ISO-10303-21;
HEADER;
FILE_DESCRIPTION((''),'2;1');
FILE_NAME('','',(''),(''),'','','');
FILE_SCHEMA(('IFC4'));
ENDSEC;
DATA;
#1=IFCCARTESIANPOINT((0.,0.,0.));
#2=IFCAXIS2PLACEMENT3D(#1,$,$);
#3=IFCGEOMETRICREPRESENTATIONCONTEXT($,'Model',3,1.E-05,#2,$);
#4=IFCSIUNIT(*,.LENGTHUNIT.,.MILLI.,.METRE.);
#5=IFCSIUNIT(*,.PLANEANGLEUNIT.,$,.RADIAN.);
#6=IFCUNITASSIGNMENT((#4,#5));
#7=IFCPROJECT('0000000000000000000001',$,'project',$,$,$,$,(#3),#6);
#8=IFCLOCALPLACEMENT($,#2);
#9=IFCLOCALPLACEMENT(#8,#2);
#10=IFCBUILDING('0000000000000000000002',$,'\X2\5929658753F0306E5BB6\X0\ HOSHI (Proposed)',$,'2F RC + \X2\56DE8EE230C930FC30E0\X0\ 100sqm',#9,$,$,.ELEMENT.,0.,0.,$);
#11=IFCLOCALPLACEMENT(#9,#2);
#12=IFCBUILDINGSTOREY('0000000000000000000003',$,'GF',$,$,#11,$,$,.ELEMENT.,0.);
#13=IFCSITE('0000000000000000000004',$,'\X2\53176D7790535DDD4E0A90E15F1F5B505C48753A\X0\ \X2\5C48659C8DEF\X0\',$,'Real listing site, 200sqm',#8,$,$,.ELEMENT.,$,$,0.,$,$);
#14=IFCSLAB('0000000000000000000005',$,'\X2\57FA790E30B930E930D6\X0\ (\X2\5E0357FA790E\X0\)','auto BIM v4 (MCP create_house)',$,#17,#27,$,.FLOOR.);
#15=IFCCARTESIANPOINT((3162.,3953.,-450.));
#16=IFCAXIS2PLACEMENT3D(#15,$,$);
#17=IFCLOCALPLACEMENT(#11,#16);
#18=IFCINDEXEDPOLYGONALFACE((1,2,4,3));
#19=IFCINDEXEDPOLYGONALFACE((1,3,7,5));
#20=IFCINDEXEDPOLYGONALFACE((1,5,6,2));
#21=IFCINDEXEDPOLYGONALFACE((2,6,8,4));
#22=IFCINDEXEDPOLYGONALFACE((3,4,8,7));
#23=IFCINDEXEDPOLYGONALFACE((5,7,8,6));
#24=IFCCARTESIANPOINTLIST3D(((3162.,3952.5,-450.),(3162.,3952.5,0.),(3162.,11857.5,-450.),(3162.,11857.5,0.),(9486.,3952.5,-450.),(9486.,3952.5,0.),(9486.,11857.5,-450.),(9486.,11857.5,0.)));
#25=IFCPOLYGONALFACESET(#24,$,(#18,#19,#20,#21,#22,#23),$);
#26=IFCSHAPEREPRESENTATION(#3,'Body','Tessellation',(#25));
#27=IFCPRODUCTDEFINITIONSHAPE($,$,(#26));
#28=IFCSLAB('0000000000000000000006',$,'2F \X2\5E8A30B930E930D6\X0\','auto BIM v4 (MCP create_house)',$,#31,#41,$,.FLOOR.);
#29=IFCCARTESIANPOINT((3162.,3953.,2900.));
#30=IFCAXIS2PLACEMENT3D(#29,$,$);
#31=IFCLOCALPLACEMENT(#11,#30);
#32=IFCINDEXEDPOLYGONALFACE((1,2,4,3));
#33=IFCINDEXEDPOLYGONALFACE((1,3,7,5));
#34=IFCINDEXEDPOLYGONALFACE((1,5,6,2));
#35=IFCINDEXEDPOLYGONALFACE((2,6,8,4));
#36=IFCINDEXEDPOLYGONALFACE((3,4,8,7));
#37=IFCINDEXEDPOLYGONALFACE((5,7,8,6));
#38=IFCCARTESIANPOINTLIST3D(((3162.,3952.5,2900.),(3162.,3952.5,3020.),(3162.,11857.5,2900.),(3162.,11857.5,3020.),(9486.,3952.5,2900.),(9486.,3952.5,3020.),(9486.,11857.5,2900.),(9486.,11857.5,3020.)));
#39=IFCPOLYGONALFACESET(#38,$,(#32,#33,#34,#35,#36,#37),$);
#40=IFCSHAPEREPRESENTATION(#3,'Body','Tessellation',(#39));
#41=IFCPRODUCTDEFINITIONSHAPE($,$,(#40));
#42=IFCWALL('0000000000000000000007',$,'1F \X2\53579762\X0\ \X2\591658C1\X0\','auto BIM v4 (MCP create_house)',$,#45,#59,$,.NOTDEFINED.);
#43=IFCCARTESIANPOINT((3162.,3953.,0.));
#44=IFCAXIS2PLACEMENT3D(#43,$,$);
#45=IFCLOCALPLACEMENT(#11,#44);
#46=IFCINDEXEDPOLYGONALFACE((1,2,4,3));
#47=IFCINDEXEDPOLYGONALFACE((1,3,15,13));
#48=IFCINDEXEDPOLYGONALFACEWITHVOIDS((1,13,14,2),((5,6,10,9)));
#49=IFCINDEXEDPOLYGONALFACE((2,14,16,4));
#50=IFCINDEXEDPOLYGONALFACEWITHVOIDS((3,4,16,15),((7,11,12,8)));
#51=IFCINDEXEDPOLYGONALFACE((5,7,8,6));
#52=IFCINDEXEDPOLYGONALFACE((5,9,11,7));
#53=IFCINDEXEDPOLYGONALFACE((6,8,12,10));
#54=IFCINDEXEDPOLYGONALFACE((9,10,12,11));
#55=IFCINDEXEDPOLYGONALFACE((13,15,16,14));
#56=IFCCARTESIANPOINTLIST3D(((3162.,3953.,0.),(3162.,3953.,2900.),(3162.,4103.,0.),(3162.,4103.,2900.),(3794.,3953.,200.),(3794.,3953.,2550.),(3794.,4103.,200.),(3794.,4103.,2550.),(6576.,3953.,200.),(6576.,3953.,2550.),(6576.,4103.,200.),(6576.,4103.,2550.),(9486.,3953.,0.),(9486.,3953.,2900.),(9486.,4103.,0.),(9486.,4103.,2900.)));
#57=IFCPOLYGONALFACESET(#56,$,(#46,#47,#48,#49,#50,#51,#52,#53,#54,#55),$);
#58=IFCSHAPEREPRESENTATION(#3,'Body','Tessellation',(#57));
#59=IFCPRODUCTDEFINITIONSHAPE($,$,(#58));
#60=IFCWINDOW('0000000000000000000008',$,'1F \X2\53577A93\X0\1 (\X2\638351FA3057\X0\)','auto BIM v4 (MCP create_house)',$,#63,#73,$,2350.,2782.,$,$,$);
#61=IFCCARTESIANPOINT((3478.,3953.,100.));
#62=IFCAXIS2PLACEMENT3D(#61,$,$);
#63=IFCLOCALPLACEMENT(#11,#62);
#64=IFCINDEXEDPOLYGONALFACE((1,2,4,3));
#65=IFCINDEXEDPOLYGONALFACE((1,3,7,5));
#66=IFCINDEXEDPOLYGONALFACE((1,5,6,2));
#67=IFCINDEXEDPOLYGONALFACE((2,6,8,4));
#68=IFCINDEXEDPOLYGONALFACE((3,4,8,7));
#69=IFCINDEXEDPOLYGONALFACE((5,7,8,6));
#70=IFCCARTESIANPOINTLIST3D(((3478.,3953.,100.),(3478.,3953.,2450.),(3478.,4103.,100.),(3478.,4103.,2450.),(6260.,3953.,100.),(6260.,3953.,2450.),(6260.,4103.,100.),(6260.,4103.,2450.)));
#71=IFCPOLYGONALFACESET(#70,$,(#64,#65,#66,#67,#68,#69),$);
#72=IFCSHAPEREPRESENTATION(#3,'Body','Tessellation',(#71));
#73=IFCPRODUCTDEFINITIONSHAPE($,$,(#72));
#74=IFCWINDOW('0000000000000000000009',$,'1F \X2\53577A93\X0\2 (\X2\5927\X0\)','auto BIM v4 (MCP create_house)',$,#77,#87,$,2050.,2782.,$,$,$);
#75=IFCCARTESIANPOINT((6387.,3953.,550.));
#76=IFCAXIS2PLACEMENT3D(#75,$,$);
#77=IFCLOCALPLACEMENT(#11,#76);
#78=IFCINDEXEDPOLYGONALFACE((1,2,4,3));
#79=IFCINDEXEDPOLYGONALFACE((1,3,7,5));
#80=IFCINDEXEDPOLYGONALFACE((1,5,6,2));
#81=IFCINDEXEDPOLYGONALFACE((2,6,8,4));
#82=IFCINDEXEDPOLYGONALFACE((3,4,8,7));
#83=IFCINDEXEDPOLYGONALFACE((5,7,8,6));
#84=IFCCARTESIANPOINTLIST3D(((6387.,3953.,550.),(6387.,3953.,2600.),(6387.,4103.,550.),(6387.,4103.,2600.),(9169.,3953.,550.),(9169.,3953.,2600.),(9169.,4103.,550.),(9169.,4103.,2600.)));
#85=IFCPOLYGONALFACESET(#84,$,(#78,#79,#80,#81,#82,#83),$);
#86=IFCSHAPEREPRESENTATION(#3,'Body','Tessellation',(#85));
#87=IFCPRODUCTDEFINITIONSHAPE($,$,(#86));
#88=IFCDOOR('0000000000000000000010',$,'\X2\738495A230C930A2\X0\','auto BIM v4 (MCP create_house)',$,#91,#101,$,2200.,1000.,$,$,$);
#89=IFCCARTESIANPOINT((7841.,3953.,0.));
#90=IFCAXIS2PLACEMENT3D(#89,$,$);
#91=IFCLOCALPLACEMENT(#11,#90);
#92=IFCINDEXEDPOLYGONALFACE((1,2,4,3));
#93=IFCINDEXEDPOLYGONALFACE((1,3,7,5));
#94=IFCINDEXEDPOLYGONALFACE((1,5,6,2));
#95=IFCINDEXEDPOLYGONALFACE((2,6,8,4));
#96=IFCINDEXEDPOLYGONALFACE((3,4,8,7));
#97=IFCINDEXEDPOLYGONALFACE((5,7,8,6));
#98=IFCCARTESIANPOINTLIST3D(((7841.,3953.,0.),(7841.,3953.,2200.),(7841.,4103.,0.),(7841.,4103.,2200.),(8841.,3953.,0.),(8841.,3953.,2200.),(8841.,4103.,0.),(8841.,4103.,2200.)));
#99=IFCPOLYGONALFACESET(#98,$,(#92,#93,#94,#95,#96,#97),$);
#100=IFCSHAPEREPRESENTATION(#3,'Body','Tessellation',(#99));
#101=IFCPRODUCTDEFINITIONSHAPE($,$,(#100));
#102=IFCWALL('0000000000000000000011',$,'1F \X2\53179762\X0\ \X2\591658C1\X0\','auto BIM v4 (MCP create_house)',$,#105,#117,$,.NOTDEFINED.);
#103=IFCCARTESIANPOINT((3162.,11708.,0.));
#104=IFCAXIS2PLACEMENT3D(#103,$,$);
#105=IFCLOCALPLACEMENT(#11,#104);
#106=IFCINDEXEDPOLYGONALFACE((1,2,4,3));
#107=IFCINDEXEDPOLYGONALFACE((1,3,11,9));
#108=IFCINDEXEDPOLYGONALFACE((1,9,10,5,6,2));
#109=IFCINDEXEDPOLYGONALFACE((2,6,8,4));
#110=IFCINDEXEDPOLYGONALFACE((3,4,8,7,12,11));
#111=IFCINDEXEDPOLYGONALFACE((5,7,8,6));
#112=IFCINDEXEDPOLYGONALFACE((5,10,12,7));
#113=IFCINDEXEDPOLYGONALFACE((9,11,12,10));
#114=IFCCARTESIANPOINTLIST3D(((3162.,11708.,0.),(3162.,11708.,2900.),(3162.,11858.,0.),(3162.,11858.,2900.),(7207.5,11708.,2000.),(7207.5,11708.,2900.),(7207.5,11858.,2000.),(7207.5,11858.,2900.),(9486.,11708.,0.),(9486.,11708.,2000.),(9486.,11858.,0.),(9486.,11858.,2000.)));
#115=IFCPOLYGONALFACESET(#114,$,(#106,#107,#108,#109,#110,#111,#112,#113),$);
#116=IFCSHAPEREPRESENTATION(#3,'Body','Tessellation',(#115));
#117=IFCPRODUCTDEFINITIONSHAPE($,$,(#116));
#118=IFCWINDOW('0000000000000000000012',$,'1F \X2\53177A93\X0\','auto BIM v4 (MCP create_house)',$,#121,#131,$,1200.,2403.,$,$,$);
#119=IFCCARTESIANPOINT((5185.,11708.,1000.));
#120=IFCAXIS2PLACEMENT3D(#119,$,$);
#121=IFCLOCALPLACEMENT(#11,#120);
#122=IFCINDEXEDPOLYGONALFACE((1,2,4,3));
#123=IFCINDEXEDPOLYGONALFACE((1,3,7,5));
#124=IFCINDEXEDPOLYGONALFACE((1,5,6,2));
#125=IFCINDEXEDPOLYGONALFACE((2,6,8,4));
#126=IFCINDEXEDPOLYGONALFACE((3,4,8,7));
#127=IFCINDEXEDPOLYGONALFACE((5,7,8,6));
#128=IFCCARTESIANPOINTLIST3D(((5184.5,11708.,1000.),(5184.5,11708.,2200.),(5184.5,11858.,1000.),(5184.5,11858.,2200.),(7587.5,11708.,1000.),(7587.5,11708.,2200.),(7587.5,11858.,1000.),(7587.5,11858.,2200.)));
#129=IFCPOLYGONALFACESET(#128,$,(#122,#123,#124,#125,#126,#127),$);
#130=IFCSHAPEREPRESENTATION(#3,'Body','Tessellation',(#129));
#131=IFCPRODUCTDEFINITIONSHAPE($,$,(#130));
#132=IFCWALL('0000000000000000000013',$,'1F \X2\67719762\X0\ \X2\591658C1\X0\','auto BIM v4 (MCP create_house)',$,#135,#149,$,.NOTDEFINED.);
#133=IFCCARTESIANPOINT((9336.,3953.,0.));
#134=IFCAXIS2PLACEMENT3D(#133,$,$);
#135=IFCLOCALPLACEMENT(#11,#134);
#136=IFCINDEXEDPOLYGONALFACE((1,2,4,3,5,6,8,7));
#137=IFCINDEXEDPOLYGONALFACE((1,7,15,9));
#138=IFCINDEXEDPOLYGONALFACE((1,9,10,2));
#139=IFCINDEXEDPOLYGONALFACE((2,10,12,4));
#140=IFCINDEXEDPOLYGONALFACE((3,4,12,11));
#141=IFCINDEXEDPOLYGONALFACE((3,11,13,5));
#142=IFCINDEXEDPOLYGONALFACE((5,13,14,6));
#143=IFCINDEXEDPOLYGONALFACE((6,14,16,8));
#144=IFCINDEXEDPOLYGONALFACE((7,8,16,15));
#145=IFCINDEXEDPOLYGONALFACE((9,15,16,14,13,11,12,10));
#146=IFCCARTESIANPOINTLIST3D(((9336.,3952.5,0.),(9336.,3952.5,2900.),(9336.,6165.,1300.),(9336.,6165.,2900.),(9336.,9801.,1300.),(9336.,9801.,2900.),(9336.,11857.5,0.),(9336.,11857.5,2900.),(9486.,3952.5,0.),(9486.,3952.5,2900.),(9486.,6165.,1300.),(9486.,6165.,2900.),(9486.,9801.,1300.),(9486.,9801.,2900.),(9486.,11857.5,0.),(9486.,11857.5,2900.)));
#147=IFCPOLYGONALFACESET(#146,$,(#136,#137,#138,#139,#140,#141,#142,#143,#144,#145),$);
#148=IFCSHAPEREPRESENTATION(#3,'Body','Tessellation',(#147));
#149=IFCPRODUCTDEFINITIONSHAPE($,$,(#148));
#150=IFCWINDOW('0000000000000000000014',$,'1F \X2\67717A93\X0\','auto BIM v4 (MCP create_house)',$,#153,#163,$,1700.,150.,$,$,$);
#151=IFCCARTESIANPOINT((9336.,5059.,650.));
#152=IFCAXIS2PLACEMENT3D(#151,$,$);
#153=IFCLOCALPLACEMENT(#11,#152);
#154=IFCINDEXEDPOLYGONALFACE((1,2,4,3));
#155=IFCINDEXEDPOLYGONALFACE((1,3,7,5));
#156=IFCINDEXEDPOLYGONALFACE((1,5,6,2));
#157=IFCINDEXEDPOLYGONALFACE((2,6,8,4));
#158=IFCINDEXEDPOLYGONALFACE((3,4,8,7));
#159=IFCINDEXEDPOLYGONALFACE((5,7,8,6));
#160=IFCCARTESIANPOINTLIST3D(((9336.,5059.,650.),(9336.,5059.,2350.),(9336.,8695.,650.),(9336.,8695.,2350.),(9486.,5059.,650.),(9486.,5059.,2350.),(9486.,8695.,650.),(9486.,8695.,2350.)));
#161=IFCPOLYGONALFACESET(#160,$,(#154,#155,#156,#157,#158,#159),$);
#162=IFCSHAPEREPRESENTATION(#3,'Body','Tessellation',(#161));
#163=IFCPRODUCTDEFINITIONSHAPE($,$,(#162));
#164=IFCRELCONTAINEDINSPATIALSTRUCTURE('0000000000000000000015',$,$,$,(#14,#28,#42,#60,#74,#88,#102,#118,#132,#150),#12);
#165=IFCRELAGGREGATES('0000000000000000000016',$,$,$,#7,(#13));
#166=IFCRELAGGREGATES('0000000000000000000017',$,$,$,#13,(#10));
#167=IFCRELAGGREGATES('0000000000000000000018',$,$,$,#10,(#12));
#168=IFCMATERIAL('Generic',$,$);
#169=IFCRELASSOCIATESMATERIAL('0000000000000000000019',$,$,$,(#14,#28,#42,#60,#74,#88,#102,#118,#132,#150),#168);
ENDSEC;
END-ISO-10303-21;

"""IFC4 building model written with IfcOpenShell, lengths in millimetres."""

from ifc_helpers import new_model, si_unit, frame, frame_2d, origin, place, context, project, spatial, rectangle, extrude, material, element, fill, save


model = new_model("IFC4")

# Units and contexts
model_context = context("Model", 3, precision=1e-05, world=origin())
ifc_project = project(units=[si_unit("LENGTHUNIT", "METRE", prefix="MILLI"), si_unit("PLANEANGLEUNIT", "RADIAN")], contexts=[model_context])

# Site, building, storey
site_placement = place(None, origin())
site = spatial("IfcSite", under=ifc_project, at=site_placement, Name="北海道川上郡弟子屈町 屈斜路", ObjectType="Real listing site, 200sqm", CompositionType="ELEMENT", RefElevation=0.0)
building_placement = place(site_placement, origin())
building = spatial("IfcBuilding", under=site, at=building_placement, Name="天文台の家 HOSHI (Proposed)", ObjectType="2F RC + 回転ドーム 100sqm", CompositionType="ELEMENT", ElevationOfRefHeight=0.0, ElevationOfTerrain=0.0)
storey_placement = place(building_placement, origin())
storey = spatial("IfcBuildingStorey", under=building, at=storey_placement, Name="GF", CompositionType="ELEMENT", Elevation=0.0)

# Slabs
ifc_material = material(Name="Generic")
slab_1_placement = place(storey_placement, frame((3162.0, 3953.0, -450.0)))
element("IfcSlab", 1, at=slab_1_placement, inside=storey, material=ifc_material, Name="基礎スラブ (布基礎)", Description="auto BIM v4 (MCP create_house)", PredefinedType="FLOOR", context=model_context, shape_type="SweptSolid", body=[
    extrude(rectangle(XDim=6324.0, YDim=7905.0, at=frame_2d((3162.0, 3952.0))), frame((3162.0, 3953.0, -450.0)), (0.0, 0.0, 1.0), 450.0),
])
slab_2_placement = place(storey_placement, frame((3162.0, 3953.0, 2900.0)))
element("IfcSlab", 2, at=slab_2_placement, inside=storey, material=ifc_material, Name="2F 床スラブ", Description="auto BIM v4 (MCP create_house)", PredefinedType="FLOOR", context=model_context, shape_type="SweptSolid", body=[
    extrude(rectangle(XDim=6324.0, YDim=7905.0, at=frame_2d((3162.0, 3952.0))), frame((3162.0, 3953.0, 2900.0)), (0.0, 0.0, 1.0), 120.0),
])

# Wall, openings, windows, door
wall_1_placement = place(storey_placement, frame((3162.0, 3953.0, 0.0)))
wall_1 = element("IfcWall", 3, at=wall_1_placement, inside=storey, material=ifc_material, Name="1F 南面 外壁", Description="auto BIM v4 (MCP create_house)", PredefinedType="NOTDEFINED", context=model_context, shape_type="SweptSolid", body=[
    extrude(rectangle(XDim=6324.0, YDim=150.0, at=frame_2d((3162.0, 75.0))), frame((3162.0, 3953.0, 0.0)), (0.0, 0.0, 1.0), 2900.0),
])
opening_1_placement = place(storey_placement, frame((3478.0, 3953.0, 100.0)))
opening_1 = element("IfcOpeningElement", 4, at=opening_1_placement, cuts=wall_1, PredefinedType="NOTDEFINED", context=model_context, shape_type="SweptSolid", body=[
    extrude(rectangle(XDim=2782.0, YDim=150.0, at=frame_2d((1391.0, 75.0))), frame((3478.0, 3953.0, 100.0)), (0.0, 0.0, 1.0), 2350.0),
])
opening_2_placement = place(storey_placement, frame((6387.0, 3953.0, 550.0)))
opening_2 = element("IfcOpeningElement", 5, at=opening_2_placement, cuts=wall_1, PredefinedType="NOTDEFINED", context=model_context, shape_type="SweptSolid", body=[
    extrude(rectangle(XDim=2782.0, YDim=150.0, at=frame_2d((1391.0, 75.0))), frame((6387.0, 3953.0, 550.0)), (0.0, 0.0, 1.0), 2050.0),
])
opening_3_placement = place(storey_placement, frame((7841.0, 3953.0, 0.0)))
opening_3 = element("IfcOpeningElement", 6, at=opening_3_placement, cuts=wall_1, PredefinedType="NOTDEFINED", context=model_context, shape_type="SweptSolid", body=[
    extrude(rectangle(XDim=1000.0, YDim=150.0, at=frame_2d((500.0, 75.0))), frame((7841.0, 3953.0, 0.0)), (0.0, 0.0, 1.0), 2200.0),
])
window_1_placement = place(storey_placement, frame((3478.0, 3953.0, 100.0)))
window_1 = element("IfcWindow", 7, at=window_1_placement, inside=storey, material=ifc_material, Name="1F 南窓1 (掃出し)", Description="auto BIM v4 (MCP create_house)", OverallHeight=2350.0, OverallWidth=2782.0, context=model_context, shape_type="SweptSolid", body=[
    extrude(rectangle(XDim=2782.0, YDim=150.0, at=frame_2d((1391.0, 75.0))), frame((3478.0, 3953.0, 100.0)), (0.0, 0.0, 1.0), 2350.0),
])
fill(opening_1, window_1)
window_2_placement = place(storey_placement, frame((6387.0, 3953.0, 550.0)))
window_2 = element("IfcWindow", 8, at=window_2_placement, inside=storey, material=ifc_material, Name="1F 南窓2 (大)", Description="auto BIM v4 (MCP create_house)", OverallHeight=2050.0, OverallWidth=2782.0, context=model_context, shape_type="SweptSolid", body=[
    extrude(rectangle(XDim=2782.0, YDim=150.0, at=frame_2d((1391.0, 75.0))), frame((6387.0, 3953.0, 550.0)), (0.0, 0.0, 1.0), 2050.0),
])
fill(opening_2, window_2)
door_1_placement = place(storey_placement, frame((7841.0, 3953.0, 0.0)))
door_1 = element("IfcDoor", 9, at=door_1_placement, inside=storey, material=ifc_material, Name="玄関ドア", Description="auto BIM v4 (MCP create_house)", OverallHeight=2200.0, OverallWidth=1000.0, context=model_context, shape_type="SweptSolid", body=[
    extrude(rectangle(XDim=1000.0, YDim=150.0, at=frame_2d((500.0, 75.0))), frame((7841.0, 3953.0, 0.0)), (0.0, 0.0, 1.0), 2200.0),
])
fill(opening_3, door_1)

# Walls, openings, windows
wall_2_placement = place(storey_placement, frame((3162.0, 11708.0, 0.0)))
wall_2 = element("IfcWall", 10, at=wall_2_placement, inside=storey, material=ifc_material, Name="1F 北面 外壁", Description="auto BIM v4 (MCP create_house)", PredefinedType="NOTDEFINED", context=model_context, shape_type="SweptSolid", body=[
    extrude(rectangle(XDim=6324.0, YDim=150.0, at=frame_2d((3162.0, 75.0))), frame((3162.0, 11708.0, 0.0)), (0.0, 0.0, 1.0), 2900.0),
])
opening_4_placement = place(storey_placement, frame((5185.0, 11708.0, 1000.0)))
opening_4 = element("IfcOpeningElement", 11, at=opening_4_placement, cuts=wall_2, PredefinedType="NOTDEFINED", context=model_context, shape_type="SweptSolid", body=[
    extrude(rectangle(XDim=2403.0, YDim=150.0, at=frame_2d((1201.0, 75.0))), frame((5185.0, 11708.0, 1000.0)), (0.0, 0.0, 1.0), 1200.0),
])
window_3_placement = place(storey_placement, frame((5185.0, 11708.0, 1000.0)))
window_3 = element("IfcWindow", 12, at=window_3_placement, inside=storey, material=ifc_material, Name="1F 北窓", Description="auto BIM v4 (MCP create_house)", OverallHeight=1200.0, OverallWidth=2403.0, context=model_context, shape_type="SweptSolid", body=[
    extrude(rectangle(XDim=2403.0, YDim=150.0, at=frame_2d((1201.0, 75.0))), frame((5185.0, 11708.0, 1000.0)), (0.0, 0.0, 1.0), 1200.0),
])
fill(opening_4, window_3)
wall_3_placement = place(storey_placement, frame((9336.0, 3953.0, 0.0)))
wall_3 = element("IfcWall", 13, at=wall_3_placement, inside=storey, material=ifc_material, Name="1F 東面 外壁", Description="auto BIM v4 (MCP create_house)", PredefinedType="NOTDEFINED", context=model_context, shape_type="SweptSolid", body=[
    extrude(rectangle(XDim=150.0, YDim=7905.0, at=frame_2d((75.0, 3952.0))), frame((9336.0, 3953.0, 0.0)), (0.0, 0.0, 1.0), 2900.0),
])
opening_5_placement = place(storey_placement, frame((9336.0, 5059.0, 650.0)))
opening_5 = element("IfcOpeningElement", 14, at=opening_5_placement, cuts=wall_3, PredefinedType="NOTDEFINED", context=model_context, shape_type="SweptSolid", body=[
    extrude(rectangle(XDim=150.0, YDim=3636.0, at=frame_2d((75.0, 1818.0))), frame((9336.0, 5059.0, 650.0)), (0.0, 0.0, 1.0), 1700.0),
])
window_4_placement = place(storey_placement, frame((9336.0, 5059.0, 650.0)))
window_4 = element("IfcWindow", 15, at=window_4_placement, inside=storey, material=ifc_material, Name="1F 東窓", Description="auto BIM v4 (MCP create_house)", OverallHeight=1700.0, OverallWidth=150.0, context=model_context, shape_type="SweptSolid", body=[
    extrude(rectangle(XDim=150.0, YDim=3636.0, at=frame_2d((75.0, 1818.0))), frame((9336.0, 5059.0, 650.0)), (0.0, 0.0, 1.0), 1700.0),
])
fill(opening_5, window_4)

save(model, "model.ifc")
